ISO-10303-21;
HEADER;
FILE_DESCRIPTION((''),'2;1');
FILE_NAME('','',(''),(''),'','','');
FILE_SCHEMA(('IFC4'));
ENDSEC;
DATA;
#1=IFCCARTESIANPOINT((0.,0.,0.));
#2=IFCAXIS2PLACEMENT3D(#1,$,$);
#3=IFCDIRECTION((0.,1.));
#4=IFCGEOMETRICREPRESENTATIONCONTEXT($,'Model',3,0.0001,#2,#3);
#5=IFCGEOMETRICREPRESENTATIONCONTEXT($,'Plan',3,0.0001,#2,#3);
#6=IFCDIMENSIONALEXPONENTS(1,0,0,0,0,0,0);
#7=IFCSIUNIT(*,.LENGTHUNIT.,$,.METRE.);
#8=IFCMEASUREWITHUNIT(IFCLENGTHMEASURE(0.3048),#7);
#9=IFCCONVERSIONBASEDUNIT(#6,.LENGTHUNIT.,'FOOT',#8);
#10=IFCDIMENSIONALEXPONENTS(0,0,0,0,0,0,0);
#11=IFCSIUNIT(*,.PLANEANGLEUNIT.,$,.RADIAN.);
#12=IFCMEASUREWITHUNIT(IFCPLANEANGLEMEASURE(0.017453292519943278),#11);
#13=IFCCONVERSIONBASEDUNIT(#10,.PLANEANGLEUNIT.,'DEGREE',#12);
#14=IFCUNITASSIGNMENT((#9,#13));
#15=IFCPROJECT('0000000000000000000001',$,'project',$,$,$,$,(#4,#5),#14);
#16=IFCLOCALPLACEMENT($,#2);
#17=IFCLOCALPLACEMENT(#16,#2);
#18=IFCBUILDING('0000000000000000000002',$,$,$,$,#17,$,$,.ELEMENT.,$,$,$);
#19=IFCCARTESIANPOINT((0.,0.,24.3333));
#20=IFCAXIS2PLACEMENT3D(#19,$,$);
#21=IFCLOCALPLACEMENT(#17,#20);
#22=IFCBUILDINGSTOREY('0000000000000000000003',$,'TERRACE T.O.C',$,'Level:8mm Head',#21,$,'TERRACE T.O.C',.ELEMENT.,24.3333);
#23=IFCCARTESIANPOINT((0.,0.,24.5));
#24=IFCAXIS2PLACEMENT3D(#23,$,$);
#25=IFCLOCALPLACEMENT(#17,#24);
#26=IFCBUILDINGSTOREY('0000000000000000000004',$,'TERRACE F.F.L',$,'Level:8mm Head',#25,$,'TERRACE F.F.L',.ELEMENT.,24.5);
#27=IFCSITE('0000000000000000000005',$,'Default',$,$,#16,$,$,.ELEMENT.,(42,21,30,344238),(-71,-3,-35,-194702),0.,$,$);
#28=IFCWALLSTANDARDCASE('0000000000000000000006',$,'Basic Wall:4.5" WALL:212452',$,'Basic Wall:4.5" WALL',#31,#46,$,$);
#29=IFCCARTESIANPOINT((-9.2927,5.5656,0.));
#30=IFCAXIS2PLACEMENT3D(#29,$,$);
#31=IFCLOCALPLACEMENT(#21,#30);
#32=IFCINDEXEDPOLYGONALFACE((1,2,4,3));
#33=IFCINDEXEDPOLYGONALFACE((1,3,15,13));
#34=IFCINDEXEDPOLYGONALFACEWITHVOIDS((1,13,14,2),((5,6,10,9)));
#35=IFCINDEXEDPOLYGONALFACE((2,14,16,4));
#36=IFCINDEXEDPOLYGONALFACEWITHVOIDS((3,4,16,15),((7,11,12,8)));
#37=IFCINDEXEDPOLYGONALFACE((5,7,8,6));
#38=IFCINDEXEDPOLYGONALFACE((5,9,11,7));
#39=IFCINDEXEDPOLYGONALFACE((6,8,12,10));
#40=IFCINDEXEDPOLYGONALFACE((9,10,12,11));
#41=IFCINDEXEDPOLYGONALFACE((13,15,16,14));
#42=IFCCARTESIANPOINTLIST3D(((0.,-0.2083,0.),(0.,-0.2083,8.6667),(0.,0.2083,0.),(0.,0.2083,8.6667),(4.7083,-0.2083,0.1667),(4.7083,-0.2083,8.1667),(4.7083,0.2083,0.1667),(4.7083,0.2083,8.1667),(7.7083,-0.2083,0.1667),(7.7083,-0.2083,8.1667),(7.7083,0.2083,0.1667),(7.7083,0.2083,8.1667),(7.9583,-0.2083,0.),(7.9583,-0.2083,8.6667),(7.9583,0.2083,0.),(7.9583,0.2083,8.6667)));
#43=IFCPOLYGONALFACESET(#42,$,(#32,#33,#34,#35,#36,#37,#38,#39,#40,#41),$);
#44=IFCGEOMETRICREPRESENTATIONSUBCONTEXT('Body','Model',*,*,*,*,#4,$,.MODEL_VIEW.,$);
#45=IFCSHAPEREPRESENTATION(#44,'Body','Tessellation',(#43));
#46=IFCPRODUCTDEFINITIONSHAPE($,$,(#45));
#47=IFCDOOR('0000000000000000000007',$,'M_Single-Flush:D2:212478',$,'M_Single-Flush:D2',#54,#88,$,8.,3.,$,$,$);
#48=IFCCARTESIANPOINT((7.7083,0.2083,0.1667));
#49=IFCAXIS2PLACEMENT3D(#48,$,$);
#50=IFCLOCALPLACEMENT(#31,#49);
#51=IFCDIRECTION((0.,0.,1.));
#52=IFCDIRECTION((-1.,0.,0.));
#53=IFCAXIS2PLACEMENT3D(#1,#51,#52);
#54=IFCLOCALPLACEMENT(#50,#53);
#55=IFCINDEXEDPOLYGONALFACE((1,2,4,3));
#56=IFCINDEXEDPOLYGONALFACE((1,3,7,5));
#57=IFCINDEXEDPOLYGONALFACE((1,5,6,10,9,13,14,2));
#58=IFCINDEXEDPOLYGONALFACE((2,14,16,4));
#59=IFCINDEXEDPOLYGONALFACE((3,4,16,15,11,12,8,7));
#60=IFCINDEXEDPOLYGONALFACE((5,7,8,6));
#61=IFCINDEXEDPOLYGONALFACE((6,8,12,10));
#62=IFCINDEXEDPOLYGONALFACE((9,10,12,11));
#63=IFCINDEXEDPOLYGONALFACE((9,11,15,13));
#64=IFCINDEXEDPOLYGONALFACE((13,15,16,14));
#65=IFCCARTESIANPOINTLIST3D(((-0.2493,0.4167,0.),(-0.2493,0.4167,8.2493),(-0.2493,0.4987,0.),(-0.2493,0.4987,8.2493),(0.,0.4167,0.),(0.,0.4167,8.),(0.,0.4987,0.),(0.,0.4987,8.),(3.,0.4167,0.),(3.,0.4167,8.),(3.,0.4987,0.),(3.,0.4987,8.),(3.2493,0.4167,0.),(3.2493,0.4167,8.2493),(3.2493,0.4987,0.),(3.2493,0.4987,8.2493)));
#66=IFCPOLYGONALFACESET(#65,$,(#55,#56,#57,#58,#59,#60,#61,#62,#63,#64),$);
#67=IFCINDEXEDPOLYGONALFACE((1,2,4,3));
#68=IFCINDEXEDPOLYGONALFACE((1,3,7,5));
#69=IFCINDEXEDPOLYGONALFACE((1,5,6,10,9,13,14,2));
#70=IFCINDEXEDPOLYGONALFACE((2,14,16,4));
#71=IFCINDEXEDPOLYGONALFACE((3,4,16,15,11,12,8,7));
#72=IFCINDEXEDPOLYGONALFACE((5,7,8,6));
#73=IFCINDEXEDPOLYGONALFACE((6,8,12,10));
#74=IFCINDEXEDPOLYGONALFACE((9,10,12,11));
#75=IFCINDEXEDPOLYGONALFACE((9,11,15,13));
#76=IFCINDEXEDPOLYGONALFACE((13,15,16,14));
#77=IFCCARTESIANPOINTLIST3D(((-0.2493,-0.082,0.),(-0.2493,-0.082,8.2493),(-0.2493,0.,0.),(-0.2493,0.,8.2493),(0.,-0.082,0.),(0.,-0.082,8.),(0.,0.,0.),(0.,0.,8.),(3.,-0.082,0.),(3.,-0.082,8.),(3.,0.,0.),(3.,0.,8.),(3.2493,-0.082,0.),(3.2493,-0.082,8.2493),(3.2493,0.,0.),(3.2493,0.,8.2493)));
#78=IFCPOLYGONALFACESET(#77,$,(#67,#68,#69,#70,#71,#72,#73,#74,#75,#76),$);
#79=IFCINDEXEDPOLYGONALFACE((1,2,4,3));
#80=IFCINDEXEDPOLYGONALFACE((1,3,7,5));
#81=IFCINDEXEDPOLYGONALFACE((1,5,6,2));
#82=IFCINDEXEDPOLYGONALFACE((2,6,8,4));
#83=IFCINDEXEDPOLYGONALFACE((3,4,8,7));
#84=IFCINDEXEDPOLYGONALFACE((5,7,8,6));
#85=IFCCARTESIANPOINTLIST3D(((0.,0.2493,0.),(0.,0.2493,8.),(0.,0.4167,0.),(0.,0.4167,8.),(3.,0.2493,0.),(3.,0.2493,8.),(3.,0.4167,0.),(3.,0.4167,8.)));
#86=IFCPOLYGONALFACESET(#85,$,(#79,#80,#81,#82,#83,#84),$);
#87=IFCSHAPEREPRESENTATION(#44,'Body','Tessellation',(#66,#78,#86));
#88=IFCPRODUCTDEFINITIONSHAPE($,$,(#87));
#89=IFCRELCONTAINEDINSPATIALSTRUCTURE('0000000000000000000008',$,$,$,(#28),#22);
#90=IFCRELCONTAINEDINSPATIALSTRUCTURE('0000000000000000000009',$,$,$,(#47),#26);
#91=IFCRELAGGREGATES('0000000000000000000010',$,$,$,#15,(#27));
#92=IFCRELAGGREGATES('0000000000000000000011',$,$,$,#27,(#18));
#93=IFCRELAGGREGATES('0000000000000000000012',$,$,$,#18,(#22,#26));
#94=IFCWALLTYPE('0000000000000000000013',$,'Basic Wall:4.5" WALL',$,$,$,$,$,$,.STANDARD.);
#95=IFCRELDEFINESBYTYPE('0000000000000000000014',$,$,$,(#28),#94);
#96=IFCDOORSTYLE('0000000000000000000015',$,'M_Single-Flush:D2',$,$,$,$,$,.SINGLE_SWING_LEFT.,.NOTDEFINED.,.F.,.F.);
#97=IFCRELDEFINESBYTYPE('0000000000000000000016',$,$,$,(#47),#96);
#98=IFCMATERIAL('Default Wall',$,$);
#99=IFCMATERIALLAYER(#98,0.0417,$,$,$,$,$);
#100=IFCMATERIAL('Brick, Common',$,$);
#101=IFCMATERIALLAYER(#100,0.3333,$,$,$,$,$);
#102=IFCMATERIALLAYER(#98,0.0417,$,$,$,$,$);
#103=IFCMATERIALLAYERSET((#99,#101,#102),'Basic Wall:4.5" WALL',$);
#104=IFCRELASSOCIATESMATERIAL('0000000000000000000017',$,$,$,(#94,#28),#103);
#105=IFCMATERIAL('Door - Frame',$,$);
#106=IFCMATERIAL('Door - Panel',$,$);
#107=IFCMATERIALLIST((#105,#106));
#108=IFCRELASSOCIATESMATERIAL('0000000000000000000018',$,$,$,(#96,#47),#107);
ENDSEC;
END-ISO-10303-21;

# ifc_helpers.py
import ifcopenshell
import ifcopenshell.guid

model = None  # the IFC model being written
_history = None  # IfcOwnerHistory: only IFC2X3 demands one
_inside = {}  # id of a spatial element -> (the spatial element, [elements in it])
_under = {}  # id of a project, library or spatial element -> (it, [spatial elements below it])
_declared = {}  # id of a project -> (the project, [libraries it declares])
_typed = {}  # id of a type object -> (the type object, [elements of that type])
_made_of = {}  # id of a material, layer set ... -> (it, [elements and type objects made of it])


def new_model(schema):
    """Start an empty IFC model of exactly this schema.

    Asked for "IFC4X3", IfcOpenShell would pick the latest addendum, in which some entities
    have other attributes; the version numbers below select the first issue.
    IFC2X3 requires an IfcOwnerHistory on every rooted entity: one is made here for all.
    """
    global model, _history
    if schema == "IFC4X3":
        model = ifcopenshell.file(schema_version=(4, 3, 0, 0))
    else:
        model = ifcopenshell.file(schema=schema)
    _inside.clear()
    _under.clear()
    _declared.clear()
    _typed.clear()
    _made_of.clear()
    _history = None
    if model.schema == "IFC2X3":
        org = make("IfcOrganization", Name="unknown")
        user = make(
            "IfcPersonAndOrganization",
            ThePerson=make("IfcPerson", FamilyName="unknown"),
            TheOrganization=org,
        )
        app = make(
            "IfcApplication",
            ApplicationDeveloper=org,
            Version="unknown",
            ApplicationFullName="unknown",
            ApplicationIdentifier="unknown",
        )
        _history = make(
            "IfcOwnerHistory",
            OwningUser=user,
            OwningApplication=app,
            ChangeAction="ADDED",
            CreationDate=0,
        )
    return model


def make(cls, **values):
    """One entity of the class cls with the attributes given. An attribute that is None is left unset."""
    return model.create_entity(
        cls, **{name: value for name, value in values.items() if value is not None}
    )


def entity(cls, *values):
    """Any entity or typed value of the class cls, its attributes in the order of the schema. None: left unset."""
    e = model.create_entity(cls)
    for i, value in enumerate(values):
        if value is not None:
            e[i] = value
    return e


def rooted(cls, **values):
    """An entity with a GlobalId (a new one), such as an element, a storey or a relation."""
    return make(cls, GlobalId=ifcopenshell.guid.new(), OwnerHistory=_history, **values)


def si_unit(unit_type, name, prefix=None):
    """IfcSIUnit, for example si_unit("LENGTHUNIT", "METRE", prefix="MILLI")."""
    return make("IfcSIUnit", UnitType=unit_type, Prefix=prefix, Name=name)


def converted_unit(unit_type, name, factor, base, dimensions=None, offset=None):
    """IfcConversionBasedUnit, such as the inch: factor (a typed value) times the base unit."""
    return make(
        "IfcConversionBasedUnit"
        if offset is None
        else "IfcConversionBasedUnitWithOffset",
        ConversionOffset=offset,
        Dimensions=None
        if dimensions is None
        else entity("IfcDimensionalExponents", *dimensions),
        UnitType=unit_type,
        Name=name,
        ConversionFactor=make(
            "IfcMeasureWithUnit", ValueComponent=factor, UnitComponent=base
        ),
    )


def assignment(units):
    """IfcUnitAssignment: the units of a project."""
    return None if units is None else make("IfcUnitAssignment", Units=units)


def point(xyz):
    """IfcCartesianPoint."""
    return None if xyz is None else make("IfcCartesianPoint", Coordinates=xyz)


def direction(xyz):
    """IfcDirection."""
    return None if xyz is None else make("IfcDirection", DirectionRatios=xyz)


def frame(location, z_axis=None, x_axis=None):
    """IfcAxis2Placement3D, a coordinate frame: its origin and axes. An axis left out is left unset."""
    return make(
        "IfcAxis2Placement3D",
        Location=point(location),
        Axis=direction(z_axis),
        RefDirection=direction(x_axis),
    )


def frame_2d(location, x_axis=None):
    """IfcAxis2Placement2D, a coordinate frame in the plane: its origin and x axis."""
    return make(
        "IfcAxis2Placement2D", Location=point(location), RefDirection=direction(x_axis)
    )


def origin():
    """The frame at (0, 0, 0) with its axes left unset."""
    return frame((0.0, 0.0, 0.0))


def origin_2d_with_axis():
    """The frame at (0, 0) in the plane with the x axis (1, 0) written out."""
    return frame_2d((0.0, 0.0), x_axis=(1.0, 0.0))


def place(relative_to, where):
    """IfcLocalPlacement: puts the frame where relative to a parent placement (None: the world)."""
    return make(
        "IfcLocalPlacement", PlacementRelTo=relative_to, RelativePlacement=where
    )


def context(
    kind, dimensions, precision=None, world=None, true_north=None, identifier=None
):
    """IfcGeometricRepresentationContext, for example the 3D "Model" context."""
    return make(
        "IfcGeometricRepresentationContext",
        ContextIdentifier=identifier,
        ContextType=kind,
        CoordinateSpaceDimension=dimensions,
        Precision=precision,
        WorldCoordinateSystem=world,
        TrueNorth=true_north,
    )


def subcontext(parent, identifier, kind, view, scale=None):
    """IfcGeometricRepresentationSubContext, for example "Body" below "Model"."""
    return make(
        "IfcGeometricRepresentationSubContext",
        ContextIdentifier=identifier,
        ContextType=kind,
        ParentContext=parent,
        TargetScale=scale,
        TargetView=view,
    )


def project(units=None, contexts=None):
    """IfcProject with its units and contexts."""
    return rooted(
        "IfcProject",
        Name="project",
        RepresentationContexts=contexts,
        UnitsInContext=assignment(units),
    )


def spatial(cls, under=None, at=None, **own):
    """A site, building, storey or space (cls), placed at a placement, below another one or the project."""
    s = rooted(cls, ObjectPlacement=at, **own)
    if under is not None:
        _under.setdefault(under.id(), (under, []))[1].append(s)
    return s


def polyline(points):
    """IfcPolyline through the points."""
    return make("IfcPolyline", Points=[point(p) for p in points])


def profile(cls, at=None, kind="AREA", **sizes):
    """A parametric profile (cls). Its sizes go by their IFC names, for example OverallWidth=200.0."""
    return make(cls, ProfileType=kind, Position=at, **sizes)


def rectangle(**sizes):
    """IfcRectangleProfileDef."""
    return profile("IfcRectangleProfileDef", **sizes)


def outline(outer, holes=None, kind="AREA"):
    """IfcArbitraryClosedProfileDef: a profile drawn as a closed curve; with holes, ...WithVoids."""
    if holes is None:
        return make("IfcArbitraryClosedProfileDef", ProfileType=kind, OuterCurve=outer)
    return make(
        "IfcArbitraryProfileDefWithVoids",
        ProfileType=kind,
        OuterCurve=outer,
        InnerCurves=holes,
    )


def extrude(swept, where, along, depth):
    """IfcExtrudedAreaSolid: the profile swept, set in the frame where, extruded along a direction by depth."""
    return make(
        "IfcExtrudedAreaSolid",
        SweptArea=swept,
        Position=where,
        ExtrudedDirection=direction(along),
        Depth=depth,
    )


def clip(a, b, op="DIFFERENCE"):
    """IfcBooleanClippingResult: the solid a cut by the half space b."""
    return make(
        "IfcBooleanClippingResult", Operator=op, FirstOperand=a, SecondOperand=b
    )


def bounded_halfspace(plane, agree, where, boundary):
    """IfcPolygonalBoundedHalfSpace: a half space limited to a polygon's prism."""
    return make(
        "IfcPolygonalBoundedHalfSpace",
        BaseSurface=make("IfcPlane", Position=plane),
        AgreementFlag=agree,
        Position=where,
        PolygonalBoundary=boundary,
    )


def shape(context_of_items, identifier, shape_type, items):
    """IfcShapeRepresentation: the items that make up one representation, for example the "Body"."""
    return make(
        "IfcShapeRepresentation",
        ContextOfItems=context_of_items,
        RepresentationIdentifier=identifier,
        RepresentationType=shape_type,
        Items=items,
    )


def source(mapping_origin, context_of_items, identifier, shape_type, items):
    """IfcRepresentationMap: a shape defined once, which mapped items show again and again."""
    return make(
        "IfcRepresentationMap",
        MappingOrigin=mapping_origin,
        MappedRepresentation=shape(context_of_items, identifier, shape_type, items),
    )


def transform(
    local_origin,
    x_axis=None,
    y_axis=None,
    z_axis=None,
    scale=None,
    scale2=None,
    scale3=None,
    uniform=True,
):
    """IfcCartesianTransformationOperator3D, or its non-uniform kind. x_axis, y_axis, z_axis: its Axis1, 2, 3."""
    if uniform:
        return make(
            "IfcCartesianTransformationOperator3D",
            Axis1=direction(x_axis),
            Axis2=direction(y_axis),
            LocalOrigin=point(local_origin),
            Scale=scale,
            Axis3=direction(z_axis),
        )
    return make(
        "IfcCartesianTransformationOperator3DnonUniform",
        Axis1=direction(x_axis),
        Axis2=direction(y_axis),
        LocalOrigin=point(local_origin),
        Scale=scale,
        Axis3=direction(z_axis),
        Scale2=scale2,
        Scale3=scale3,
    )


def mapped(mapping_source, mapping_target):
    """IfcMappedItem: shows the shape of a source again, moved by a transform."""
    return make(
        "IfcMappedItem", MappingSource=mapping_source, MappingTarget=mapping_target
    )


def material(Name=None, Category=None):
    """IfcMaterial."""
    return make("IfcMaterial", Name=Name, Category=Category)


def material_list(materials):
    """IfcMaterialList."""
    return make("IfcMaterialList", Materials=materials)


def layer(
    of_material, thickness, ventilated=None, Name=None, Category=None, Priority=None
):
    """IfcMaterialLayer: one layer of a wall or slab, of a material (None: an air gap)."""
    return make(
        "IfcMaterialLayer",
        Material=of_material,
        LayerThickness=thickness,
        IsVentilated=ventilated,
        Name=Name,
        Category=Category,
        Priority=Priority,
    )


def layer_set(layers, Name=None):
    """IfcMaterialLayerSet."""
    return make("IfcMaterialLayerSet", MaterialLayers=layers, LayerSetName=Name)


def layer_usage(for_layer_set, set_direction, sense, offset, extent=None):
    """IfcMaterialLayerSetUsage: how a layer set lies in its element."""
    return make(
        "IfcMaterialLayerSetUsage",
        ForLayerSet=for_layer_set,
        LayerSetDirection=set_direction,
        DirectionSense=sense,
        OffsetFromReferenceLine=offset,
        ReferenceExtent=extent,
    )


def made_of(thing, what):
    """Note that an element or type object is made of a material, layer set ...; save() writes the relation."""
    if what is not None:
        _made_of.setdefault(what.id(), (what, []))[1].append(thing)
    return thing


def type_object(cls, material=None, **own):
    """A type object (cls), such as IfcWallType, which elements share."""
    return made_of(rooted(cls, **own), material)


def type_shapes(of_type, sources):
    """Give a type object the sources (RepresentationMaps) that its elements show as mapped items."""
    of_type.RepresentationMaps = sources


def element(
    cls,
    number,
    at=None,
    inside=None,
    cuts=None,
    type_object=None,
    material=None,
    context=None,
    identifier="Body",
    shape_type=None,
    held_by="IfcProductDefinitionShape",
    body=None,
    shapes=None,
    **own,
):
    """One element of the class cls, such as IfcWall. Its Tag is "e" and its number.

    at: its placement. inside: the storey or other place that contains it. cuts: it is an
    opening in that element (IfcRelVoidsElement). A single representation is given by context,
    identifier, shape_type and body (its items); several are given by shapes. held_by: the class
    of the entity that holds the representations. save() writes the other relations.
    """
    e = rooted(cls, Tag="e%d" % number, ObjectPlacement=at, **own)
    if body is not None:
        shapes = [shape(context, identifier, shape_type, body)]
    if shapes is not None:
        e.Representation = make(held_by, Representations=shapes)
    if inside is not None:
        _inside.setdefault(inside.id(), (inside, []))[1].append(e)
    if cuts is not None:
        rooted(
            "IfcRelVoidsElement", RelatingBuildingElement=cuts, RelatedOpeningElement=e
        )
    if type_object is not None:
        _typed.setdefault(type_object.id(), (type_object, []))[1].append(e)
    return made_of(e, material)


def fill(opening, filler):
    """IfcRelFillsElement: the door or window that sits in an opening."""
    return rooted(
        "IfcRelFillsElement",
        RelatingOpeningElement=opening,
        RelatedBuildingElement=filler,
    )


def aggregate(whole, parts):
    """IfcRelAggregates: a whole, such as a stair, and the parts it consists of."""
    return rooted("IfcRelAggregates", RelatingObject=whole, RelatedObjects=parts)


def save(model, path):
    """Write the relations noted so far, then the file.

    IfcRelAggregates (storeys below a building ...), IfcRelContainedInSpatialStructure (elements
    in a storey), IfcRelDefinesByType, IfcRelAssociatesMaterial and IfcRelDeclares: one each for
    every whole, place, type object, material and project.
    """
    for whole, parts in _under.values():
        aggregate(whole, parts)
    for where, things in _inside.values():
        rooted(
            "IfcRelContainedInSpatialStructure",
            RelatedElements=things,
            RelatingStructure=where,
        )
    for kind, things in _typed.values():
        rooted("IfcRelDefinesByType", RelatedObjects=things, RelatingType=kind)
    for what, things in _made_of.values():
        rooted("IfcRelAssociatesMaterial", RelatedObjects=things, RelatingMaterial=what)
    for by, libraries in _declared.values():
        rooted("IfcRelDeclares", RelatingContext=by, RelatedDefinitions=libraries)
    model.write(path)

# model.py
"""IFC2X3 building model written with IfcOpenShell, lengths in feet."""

from ifc_helpers import new_model, entity, si_unit, converted_unit, direction, frame, frame_2d, origin, origin_2d_with_axis, place, context, subcontext, project, spatial, polyline, rectangle, outline, extrude, clip, bounded_halfspace, source, transform, mapped, material, material_list, layer, layer_set, layer_usage, type_object, type_shapes, element, fill, save


model = new_model("IFC2X3")

# Units and contexts
model_context = context("Model", 3, precision=0.0001, world=origin(), true_north=direction((0.0, 1.0)))
plan_context = context("Plan", 3, precision=0.0001, world=origin(), true_north=direction((0.0, 1.0)))
body_context = subcontext(model_context, "Body", "Model", "MODEL_VIEW")
ifc_project = project(units=[converted_unit("LENGTHUNIT", "FOOT", entity("IfcLengthMeasure", 0.3048), si_unit("LENGTHUNIT", "METRE"), dimensions=[1, 0, 0, 0, 0, 0, 0]), converted_unit("PLANEANGLEUNIT", "DEGREE", entity("IfcPlaneAngleMeasure", 0.017453292519943278), si_unit("PLANEANGLEUNIT", "RADIAN"), dimensions=[0, 0, 0, 0, 0, 0, 0])], contexts=[model_context, plan_context])

# Site, building, storey
site_placement = place(None, origin())
site = spatial("IfcSite", under=ifc_project, at=site_placement, Name="Default", CompositionType="ELEMENT", RefLatitude=(42, 21, 30, 344238), RefLongitude=(-71, -3, -35, -194702), RefElevation=0.0)
building_placement = place(site_placement, origin())
building = spatial("IfcBuilding", under=site, at=building_placement, CompositionType="ELEMENT")
storey_1_placement = place(building_placement, frame((0.0, 0.0, 24.3333)))
storey_1 = spatial("IfcBuildingStorey", under=building, at=storey_1_placement, Name="TERRACE T.O.C", ObjectType="Level:8mm Head", LongName="TERRACE T.O.C", CompositionType="ELEMENT", Elevation=24.3333)

# Shared definitions
ifc_material_1 = material(Name="Default Wall")
ifc_material_2 = material(Name="Brick, Common")

# Shared definitions
ifc_layer_1 = layer(ifc_material_1, 0.0417)
ifc_layer_2 = layer(ifc_material_2, 0.3333)
ifc_layer_3 = layer(ifc_material_1, 0.0417)
ifc_layer_set_1 = layer_set([ifc_layer_1, ifc_layer_2, ifc_layer_3], Name="Basic Wall:4.5\" WALL")
wall_type_1 = type_object("IfcWallType", Name="Basic Wall:4.5\" WALL", PredefinedType="STANDARD", material=ifc_layer_set_1)

# Shared definitions
storey_2_placement = place(building_placement, frame((0.0, 0.0, 24.5)))
storey_2 = spatial("IfcBuildingStorey", under=building, at=storey_2_placement, Name="TERRACE F.F.L", ObjectType="Level:8mm Head", LongName="TERRACE F.F.L", CompositionType="ELEMENT", Elevation=24.5)

# Wall, opening, door
ifc_layer_usage_1 = layer_usage(ifc_layer_set_1, "AXIS2", "NEGATIVE", 0.2083)
wall_1_placement = place(storey_1_placement, frame((-9.2927, 5.5656, 0.0)))
wall_1 = element("IfcWallStandardCase", 1, at=wall_1_placement, inside=storey_1, type_object=wall_type_1, material=ifc_layer_usage_1, Name="Basic Wall:4.5\" WALL:212452", ObjectType="Basic Wall:4.5\" WALL", context=body_context, shape_type="Clipping", body=[
    clip(extrude(rectangle(XDim=7.9583, YDim=0.4167, at=frame_2d((3.9792, 0.0), x_axis=(-1.0, 0.0))), origin(), (0.0, 0.0, 1.0), 8.6667), bounded_halfspace(frame((0.0, -0.2083, 8.6667), z_axis=(0.0, 0.0, -1.0), x_axis=(0.0, -1.0, 0.0)), True, frame((0.0, -0.2083, 8.6667)), polyline([(0.0, 0.0), (7.9583, 0.0), (7.9583, 0.4167), (0.0, 0.4167), (0.0, 0.0)]))),
])
opening_1_placement = place(wall_1_placement, frame((7.7083, 0.2083, 0.1667)))
opening_1 = element("IfcOpeningElement", 2, at=opening_1_placement, cuts=wall_1, ObjectType="Opening", context=body_context, shape_type="SweptSolid", body=[
    extrude(rectangle(XDim=3.0, YDim=8.0, at=frame_2d((4.0, 1.5), x_axis=(0.0, -1.0))), frame((0.0, 0.0, 0.0), z_axis=(0.0, -1.0, 0.0), x_axis=(0.0, 0.0, 1.0)), (0.0, 0.0, 1.0), 0.4167),
])
ifc_material_3 = material(Name="Door - Frame")
ifc_material_4 = material(Name="Door - Panel")
ifc_material_list_1 = material_list([ifc_material_3, ifc_material_4])
door_style = type_object("IfcDoorStyle", Name="M_Single-Flush:D2", ConstructionType="NOTDEFINED", OperationType="SINGLE_SWING_LEFT", ParameterTakesPrecedence=False, Sizeable=False, material=ifc_material_list_1)
shared_shape_1 = source(origin(), body_context, "Body", "SweptSolid", [
    extrude(outline(polyline([(-1.7493, -4.187), (1.7493, -4.187), (1.7493, 4.0623), (1.5, 4.0623), (1.5, -3.9377), (-1.5, -3.9377), (-1.5, 4.0623), (-1.7493, 4.0623), (-1.7493, -4.187)])), frame((1.5, 0.4987, 4.0623), z_axis=(0.0, -1.0, 0.0), x_axis=(-1.0, 0.0, 0.0)), (0.0, 0.0, 1.0), 0.082),
    extrude(outline(polyline([(-4.187, -1.7493), (4.0623, -1.7493), (4.0623, -1.5), (-3.9377, -1.5), (-3.9377, 1.5), (4.0623, 1.5), (4.0623, 1.7493), (-4.187, 1.7493), (-4.187, -1.7493)])), frame((1.5, 0.0, 4.0623), z_axis=(0.0, -1.0, 0.0), x_axis=(0.0, 0.0, -1.0)), (0.0, 0.0, 1.0), 0.082),
    extrude(rectangle(XDim=3.0, YDim=0.1673, at=origin_2d_with_axis()), frame((1.5, 0.333, 0.0)), (0.0, 0.0, 1.0), 8.0),
])
type_shapes(door_style, [shared_shape_1])
door_placement = place(opening_1_placement, frame((0.0, 0.0, 0.0), z_axis=(0.0, 0.0, 1.0), x_axis=(-1.0, 0.0, 0.0)))
door = element("IfcDoor", 3, at=door_placement, inside=storey_2, type_object=door_style, material=ifc_material_list_1, Name="M_Single-Flush:D2:212478", ObjectType="M_Single-Flush:D2", OverallHeight=8.0, OverallWidth=3.0, context=body_context, shape_type="MappedRepresentation", body=[
    mapped(shared_shape_1, transform((0.0, 0.0, 0.0), scale=1.0)),
])
fill(opening_1, door)

save(model, "model.ifc")
